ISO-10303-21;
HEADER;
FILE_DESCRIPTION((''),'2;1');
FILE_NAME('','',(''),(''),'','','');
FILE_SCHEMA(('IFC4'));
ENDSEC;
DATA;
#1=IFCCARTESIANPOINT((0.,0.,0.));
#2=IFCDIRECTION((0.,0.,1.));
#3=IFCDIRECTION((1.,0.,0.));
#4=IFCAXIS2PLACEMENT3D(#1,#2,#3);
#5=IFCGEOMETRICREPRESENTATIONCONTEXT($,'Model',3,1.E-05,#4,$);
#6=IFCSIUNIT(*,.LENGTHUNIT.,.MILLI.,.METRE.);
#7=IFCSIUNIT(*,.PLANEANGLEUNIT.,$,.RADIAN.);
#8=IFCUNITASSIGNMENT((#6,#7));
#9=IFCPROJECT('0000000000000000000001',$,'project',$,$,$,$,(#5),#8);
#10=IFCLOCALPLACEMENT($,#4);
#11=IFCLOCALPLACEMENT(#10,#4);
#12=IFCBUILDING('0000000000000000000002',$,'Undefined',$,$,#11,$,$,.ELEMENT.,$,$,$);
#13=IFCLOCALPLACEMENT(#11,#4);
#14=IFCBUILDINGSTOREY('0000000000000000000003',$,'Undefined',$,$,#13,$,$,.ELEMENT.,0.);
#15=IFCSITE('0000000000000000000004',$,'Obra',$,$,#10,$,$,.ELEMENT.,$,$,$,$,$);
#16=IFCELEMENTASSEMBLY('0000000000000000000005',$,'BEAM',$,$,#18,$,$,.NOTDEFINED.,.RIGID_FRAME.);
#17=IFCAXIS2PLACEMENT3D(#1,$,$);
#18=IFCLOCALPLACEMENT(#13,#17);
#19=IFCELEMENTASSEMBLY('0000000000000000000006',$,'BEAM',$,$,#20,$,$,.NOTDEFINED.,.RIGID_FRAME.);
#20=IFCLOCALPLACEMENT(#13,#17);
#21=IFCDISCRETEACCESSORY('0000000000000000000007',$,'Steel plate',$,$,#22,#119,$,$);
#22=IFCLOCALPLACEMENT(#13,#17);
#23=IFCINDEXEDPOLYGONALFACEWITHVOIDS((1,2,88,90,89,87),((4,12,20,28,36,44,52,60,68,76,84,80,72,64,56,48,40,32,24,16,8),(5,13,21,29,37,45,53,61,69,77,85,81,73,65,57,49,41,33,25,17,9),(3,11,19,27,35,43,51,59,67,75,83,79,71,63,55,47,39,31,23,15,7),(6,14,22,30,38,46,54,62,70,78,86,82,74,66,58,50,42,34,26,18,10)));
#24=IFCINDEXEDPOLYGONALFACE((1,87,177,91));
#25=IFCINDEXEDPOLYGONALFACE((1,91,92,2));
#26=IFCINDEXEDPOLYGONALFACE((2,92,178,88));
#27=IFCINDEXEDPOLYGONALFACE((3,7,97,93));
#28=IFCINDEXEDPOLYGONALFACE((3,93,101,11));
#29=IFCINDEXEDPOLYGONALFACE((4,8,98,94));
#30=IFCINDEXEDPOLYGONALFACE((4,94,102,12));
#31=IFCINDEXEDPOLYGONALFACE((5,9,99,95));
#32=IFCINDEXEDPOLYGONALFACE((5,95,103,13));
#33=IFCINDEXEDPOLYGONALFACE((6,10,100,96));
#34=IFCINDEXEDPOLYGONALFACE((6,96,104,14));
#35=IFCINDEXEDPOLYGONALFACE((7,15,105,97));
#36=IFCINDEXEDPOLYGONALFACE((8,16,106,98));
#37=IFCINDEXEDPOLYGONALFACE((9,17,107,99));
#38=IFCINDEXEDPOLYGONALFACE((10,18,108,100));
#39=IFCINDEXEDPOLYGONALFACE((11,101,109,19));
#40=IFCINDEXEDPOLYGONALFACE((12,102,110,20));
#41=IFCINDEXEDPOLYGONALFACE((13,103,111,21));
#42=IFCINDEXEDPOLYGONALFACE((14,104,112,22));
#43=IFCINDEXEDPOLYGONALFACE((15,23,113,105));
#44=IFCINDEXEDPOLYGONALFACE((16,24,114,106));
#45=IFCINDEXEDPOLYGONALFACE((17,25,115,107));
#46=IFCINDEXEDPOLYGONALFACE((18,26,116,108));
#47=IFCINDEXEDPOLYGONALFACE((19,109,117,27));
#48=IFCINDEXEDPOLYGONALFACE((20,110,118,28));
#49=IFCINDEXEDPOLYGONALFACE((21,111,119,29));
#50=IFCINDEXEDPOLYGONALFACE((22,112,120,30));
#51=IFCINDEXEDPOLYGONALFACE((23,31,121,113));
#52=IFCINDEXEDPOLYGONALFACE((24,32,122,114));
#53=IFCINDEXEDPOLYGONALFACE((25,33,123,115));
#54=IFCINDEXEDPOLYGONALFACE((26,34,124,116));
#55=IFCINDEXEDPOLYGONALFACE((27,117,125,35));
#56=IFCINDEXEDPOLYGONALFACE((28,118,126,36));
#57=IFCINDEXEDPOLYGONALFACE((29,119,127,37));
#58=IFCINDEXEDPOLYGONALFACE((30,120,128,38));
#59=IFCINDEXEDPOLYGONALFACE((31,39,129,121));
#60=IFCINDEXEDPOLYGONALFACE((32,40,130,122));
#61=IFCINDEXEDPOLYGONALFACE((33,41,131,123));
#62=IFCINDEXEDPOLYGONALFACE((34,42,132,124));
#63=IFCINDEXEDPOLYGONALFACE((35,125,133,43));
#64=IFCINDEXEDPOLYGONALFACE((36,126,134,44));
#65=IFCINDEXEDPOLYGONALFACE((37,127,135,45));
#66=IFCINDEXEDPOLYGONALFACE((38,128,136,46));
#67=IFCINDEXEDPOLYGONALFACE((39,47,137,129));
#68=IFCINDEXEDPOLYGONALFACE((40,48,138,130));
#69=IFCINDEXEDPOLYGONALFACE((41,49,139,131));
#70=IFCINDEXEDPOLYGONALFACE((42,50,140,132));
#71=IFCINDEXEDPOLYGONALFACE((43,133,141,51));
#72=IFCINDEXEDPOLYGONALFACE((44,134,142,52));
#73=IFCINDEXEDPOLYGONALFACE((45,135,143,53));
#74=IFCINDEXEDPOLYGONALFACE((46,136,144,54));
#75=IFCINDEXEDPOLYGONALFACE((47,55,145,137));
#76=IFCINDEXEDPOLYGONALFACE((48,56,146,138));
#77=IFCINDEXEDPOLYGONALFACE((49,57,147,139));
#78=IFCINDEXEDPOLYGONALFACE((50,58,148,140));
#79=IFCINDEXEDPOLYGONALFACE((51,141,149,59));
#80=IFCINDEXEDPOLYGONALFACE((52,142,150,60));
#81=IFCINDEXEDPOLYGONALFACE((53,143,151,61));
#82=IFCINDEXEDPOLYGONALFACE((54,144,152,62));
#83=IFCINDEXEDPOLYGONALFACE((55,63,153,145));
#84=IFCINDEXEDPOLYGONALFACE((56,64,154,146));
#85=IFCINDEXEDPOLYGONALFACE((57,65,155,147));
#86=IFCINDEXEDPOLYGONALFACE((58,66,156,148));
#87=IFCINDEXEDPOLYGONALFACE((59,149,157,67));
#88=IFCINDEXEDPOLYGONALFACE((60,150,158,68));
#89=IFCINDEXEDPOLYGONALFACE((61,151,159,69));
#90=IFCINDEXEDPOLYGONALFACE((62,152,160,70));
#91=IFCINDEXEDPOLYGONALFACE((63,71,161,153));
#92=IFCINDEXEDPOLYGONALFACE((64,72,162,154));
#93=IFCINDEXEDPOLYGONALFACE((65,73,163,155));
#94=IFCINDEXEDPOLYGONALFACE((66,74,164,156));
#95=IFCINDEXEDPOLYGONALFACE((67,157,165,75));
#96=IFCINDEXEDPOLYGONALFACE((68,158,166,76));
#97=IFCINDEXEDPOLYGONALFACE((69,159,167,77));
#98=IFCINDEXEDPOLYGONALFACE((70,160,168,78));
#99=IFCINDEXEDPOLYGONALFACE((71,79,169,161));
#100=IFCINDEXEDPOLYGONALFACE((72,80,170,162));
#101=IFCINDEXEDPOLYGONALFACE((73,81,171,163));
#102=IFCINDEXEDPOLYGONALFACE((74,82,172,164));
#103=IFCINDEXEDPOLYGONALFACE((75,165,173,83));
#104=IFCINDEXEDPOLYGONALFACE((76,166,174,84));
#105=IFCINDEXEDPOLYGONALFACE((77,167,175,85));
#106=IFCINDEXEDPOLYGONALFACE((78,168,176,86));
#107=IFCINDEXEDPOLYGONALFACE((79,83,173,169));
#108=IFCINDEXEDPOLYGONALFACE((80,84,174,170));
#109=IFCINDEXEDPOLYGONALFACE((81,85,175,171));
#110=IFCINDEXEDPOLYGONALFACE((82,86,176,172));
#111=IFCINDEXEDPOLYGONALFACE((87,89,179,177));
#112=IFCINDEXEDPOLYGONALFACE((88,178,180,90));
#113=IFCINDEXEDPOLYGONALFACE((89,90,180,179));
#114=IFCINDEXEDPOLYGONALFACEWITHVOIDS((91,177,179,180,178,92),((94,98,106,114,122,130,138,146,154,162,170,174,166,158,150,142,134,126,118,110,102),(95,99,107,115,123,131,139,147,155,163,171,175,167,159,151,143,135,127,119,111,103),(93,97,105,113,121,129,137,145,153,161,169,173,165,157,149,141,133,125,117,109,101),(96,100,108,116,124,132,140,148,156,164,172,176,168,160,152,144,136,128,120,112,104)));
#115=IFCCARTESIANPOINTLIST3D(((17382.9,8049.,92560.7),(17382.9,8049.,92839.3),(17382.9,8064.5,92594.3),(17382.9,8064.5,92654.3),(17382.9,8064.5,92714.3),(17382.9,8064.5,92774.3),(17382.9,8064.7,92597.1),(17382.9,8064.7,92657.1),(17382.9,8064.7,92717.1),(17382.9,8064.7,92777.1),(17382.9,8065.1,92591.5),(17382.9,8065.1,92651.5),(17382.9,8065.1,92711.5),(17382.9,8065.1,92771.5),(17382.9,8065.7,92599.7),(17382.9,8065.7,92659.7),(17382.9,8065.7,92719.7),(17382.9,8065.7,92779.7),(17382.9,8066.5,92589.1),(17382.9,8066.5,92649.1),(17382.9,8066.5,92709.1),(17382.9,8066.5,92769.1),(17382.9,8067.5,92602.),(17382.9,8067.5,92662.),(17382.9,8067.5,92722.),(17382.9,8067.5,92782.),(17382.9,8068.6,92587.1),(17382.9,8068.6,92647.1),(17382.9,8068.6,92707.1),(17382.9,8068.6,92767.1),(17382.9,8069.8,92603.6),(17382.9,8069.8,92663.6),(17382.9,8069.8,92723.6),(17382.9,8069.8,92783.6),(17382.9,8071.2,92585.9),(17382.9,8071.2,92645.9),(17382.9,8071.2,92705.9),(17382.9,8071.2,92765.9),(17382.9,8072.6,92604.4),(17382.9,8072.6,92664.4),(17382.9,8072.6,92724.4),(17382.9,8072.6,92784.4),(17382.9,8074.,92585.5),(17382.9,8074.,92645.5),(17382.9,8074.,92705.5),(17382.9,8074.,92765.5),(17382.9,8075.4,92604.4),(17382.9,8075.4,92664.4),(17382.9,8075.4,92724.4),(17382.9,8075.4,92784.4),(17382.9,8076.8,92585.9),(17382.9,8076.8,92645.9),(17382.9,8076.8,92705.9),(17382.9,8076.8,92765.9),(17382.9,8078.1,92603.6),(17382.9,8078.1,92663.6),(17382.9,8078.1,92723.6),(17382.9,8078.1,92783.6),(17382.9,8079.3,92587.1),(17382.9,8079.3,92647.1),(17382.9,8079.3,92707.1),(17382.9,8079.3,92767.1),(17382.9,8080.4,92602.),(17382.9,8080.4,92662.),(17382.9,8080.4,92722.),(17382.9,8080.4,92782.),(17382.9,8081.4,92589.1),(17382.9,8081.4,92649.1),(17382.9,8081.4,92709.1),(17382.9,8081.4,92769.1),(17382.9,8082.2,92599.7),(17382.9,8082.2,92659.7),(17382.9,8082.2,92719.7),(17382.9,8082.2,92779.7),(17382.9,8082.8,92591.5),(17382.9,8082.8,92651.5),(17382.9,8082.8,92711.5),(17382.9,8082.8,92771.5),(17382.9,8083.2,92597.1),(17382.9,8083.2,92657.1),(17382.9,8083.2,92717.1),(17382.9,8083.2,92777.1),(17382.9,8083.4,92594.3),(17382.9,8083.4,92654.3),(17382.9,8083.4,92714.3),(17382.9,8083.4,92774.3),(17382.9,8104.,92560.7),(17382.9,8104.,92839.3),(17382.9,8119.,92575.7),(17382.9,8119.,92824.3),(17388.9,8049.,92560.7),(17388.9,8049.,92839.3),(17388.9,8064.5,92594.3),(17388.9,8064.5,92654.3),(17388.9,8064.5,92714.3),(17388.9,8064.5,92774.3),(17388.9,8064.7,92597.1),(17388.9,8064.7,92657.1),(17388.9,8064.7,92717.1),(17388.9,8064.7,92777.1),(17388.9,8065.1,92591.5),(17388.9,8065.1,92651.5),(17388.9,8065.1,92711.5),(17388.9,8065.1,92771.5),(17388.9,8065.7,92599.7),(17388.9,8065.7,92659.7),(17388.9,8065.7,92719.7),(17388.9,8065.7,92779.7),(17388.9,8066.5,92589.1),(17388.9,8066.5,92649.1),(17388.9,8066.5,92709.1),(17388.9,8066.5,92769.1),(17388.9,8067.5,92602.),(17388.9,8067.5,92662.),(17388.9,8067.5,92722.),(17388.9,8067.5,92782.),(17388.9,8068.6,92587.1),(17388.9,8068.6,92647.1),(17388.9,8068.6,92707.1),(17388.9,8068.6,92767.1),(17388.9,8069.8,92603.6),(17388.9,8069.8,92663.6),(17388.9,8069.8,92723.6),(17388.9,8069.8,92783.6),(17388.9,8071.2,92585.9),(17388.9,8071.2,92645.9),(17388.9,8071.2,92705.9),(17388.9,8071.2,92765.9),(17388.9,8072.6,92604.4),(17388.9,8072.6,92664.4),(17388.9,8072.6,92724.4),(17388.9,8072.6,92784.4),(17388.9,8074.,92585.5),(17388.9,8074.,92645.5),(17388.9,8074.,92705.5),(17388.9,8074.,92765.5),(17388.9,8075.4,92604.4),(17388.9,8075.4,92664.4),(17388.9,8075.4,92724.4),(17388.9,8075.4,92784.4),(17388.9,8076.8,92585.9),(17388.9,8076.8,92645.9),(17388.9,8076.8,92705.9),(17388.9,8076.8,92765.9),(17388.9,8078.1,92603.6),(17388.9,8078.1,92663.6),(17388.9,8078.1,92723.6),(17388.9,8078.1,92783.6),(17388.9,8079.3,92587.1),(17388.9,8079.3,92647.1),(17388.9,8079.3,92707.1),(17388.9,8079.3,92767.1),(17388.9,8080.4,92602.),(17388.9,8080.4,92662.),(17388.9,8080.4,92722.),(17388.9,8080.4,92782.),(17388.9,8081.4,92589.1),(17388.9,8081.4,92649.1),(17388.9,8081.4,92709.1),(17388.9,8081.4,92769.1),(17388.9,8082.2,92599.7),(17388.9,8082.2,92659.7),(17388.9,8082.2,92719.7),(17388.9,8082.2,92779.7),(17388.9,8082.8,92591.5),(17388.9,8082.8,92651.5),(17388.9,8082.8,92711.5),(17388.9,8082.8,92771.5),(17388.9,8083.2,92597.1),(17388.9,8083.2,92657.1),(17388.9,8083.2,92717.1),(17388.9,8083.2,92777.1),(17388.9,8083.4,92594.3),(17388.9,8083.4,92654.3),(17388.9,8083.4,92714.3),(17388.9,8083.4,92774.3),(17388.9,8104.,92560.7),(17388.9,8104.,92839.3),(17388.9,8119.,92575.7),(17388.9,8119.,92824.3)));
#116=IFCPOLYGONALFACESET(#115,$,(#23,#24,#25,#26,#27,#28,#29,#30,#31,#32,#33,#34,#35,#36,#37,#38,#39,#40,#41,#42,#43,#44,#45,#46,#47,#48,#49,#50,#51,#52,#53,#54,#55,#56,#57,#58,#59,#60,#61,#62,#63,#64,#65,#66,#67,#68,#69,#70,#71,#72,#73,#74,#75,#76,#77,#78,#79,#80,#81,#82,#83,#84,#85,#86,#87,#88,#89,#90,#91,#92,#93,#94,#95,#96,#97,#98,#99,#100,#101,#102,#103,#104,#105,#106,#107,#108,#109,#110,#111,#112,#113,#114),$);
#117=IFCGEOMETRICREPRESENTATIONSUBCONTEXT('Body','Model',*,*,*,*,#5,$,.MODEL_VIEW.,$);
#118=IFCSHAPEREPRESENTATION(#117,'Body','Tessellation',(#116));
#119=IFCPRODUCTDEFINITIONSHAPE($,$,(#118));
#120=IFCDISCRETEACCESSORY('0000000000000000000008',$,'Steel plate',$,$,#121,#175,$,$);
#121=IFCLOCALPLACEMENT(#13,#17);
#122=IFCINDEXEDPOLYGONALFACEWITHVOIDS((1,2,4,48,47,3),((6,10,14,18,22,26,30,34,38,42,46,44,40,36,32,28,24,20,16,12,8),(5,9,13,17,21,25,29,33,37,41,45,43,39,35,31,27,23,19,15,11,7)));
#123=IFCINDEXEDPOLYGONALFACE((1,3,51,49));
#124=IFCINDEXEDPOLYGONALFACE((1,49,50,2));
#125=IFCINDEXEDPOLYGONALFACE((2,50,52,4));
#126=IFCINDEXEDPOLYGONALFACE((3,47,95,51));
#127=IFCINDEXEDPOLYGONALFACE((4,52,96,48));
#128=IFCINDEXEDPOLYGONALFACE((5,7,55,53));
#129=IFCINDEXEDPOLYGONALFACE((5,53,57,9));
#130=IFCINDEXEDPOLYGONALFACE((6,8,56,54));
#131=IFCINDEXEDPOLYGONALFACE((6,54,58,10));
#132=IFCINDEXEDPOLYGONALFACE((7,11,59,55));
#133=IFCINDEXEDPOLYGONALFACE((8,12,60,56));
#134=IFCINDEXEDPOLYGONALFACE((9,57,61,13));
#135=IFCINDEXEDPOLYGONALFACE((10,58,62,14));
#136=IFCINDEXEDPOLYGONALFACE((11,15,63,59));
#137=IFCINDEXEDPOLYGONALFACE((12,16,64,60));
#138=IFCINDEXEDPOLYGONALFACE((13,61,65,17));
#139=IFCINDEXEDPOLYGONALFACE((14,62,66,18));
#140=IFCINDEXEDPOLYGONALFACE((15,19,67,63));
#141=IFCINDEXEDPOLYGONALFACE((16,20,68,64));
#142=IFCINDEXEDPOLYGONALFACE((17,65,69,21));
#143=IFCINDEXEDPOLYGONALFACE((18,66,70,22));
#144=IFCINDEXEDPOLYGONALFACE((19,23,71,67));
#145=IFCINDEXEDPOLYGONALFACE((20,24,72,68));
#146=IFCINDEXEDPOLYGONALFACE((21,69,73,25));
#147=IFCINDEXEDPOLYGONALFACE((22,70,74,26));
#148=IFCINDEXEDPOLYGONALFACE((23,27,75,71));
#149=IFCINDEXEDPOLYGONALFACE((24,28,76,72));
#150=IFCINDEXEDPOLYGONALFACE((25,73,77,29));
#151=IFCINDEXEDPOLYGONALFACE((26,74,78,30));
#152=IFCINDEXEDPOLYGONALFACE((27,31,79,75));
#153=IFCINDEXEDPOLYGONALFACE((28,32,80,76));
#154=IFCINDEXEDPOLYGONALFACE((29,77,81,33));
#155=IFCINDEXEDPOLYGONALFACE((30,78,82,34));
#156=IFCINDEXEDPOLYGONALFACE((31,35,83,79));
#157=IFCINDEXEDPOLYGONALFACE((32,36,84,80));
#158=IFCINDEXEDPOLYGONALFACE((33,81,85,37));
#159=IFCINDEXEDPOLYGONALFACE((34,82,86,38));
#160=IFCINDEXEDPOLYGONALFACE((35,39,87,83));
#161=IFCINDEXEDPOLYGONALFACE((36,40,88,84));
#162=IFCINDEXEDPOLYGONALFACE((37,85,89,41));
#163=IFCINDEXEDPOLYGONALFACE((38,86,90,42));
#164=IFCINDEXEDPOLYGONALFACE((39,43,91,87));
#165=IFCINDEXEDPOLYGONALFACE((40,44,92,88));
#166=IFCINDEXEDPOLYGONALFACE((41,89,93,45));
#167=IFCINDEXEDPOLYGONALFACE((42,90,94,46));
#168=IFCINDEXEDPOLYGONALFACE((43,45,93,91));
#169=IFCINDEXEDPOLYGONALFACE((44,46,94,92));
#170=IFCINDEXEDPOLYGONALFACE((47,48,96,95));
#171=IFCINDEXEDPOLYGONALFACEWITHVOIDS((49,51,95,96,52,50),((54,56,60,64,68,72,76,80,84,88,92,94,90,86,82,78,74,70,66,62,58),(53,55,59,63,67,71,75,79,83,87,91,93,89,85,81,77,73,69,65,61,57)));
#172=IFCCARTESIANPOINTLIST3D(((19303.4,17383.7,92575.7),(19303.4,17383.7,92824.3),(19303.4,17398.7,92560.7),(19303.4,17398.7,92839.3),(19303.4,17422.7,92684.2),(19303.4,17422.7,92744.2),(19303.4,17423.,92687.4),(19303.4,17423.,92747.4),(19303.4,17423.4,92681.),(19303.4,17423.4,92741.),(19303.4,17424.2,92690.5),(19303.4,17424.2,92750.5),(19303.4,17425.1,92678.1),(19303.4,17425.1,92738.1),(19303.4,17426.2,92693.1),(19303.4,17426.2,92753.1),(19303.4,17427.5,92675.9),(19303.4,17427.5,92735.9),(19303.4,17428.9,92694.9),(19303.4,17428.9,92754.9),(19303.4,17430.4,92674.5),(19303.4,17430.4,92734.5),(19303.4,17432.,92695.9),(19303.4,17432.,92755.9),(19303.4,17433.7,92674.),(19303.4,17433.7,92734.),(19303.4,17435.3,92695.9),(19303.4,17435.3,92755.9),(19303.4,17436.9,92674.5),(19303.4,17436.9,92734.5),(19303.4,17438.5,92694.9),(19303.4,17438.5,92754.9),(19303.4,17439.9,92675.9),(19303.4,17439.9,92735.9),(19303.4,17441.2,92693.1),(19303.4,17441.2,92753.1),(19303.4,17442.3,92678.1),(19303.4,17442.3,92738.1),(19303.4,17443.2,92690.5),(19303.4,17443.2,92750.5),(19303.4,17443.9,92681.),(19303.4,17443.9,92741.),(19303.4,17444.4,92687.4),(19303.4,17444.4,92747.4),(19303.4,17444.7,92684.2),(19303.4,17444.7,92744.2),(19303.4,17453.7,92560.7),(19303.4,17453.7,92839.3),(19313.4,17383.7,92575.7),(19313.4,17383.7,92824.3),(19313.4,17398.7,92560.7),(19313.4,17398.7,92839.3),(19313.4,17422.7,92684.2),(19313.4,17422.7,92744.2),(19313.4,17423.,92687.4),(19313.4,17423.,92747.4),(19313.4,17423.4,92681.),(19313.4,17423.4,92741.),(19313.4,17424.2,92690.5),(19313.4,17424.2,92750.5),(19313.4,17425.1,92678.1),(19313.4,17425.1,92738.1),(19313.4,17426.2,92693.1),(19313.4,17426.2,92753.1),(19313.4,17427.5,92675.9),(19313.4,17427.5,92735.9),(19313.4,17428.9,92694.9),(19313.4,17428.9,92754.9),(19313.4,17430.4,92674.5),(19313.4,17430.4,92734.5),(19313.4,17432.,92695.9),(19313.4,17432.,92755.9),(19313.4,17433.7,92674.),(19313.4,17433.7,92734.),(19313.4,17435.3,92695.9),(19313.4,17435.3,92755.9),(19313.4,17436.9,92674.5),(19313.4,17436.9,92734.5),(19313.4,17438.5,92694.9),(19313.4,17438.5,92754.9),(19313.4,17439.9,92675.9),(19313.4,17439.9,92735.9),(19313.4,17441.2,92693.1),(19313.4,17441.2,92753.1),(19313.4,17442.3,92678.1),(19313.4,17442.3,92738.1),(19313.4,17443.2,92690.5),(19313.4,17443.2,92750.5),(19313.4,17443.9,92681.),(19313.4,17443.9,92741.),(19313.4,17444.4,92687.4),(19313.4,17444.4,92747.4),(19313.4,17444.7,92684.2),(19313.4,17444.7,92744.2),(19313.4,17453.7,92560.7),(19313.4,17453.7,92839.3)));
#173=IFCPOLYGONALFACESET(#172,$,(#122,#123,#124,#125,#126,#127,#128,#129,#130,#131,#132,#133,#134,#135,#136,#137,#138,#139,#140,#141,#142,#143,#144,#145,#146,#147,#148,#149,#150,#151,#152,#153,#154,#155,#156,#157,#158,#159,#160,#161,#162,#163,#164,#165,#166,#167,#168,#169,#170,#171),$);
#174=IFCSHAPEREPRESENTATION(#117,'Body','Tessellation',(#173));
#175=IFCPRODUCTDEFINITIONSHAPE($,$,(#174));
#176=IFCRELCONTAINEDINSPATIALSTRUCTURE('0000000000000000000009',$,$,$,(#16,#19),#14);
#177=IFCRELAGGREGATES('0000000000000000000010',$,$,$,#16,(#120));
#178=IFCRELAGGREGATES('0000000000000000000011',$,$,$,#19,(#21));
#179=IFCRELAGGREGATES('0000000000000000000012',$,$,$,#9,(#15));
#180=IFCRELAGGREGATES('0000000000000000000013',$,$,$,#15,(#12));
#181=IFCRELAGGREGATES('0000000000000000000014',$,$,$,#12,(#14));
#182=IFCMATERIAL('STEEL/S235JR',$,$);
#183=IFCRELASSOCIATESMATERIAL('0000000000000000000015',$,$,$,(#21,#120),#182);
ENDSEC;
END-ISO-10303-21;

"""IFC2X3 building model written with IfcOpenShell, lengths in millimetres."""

from ifc_helpers import new_model, si_unit, frame, origin_with_axes, origin_2d_with_axis, place, context, subcontext, project, spatial, polyline, circle, outline, extrude, source, transform, mapped, material, element, aggregate, save


model = new_model("IFC2X3")

# Units and contexts
model_context = context("Model", 3, precision=1e-05, world=origin_with_axes())
body_context = subcontext(model_context, "Body", "Model", "MODEL_VIEW")
ifc_project = project(units=[si_unit("LENGTHUNIT", "METRE", prefix="MILLI"), si_unit("PLANEANGLEUNIT", "RADIAN")], contexts=[model_context])

# Site, building, storey
site_placement = place(None, origin_with_axes())
site = spatial("IfcSite", under=ifc_project, at=site_placement, Name="Obra", CompositionType="ELEMENT")
building_placement = place(site_placement, origin_with_axes())
building = spatial("IfcBuilding", under=site, at=building_placement, Name="Undefined", CompositionType="ELEMENT")
storey_placement = place(building_placement, origin_with_axes())
storey = spatial("IfcBuildingStorey", under=building, at=storey_placement, Name="Undefined", CompositionType="ELEMENT", Elevation=0.0)

# Element assemblies, discrete accessory, opening
assembly_1_placement = place(storey_placement, origin_with_axes())
assembly_1 = element("IfcElementAssembly", 1, at=assembly_1_placement, inside=storey, Name="BEAM", AssemblyPlace="NOTDEFINED", PredefinedType="RIGID_FRAME")
ifc_material_1 = material(Name="STEEL/S235JR")
shared_shape_1 = source(origin_with_axes(), body_context, "Body", "SweptSolid", [
    extrude(circle(Radius=9.5, at=origin_2d_with_axis()), frame((0.0, -9.8, 0.0), z_axis=(0.0, 1.0, 0.0), x_axis=(1.0, 0.0, 0.0)), (0.0, 0.0, 1.0), 6.2),
])
assembly_2_placement = place(storey_placement, origin_with_axes())
assembly_2 = element("IfcElementAssembly", 2, at=assembly_2_placement, inside=storey, Name="BEAM", AssemblyPlace="NOTDEFINED", PredefinedType="RIGID_FRAME")
discrete_accessory_1_placement = place(assembly_2_placement, frame((17385.9, 8049.0, 92560.7), z_axis=(1.0, 0.0, 0.0), x_axis=(0.0, 1.0, 0.0)))
discrete_accessory_1 = element("IfcDiscreteAccessory", 3, at=discrete_accessory_1_placement, material=ifc_material_1, Name="Steel plate", context=body_context, shape_type="SweptSolid", body=[
    extrude(outline(polyline([(0.0, 0.0), (55.0, 0.0), (70.0, 15.0), (70.0, 263.6), (55.0, 278.6), (0.0, 278.6), (0.0, 0.0)])), frame((0.0, 0.0, -3.0), z_axis=(0.0, 0.0, 1.0), x_axis=(1.0, 0.0, 0.0)), (0.0, 0.0, 1.0), 6.0),
])
opening_1_placement = place(assembly_2_placement, frame((17392.7, 8109.0, 92850.0), z_axis=(0.0, -1.0, 0.0), x_axis=(0.0, 0.0, -1.0)))
element("IfcOpeningElement", 4, at=opening_1_placement, cuts=discrete_accessory_1, ObjectType="Opening", context=body_context, shape_type="MappedRepresentation", body=[
    mapped(shared_shape_1, transform((75.0, 0.0, 35.0))),
    mapped(shared_shape_1, transform((135.0, 0.0, 35.0))),
    mapped(shared_shape_1, transform((195.0, 0.0, 35.0))),
    mapped(shared_shape_1, transform((255.0, 0.0, 35.0))),
])

# Discrete accessory, opening
discrete_accessory_2_placement = place(assembly_1_placement, frame((19308.4, 17453.7, 92560.7), z_axis=(-1.0, 0.0, 0.0), x_axis=(0.0, -1.0, 0.0)))
discrete_accessory_2 = element("IfcDiscreteAccessory", 5, at=discrete_accessory_2_placement, material=ifc_material_1, Name="Steel plate", context=body_context, shape_type="SweptSolid", body=[
    extrude(outline(polyline([(0.0, 0.0), (55.0, 0.0), (70.0, 15.0), (70.0, 263.6), (55.0, 278.6), (0.0, 278.6), (0.0, 0.0)])), frame((0.0, 0.0, -5.0), z_axis=(0.0, 0.0, 1.0), x_axis=(1.0, 0.0, 0.0)), (0.0, 0.0, 1.0), 10.0),
])
shared_shape_2 = source(origin_with_axes(), body_context, "Body", "SweptSolid", [
    extrude(circle(Radius=11.0, at=origin_2d_with_axis()), frame((0.0, -13.4, 0.0), z_axis=(0.0, 1.0, 0.0), x_axis=(1.0, 0.0, 0.0)), (0.0, 0.0, 1.0), 10.2),
])
opening_2_placement = place(assembly_1_placement, frame((19300.1, 17393.7, 92850.0), z_axis=(0.0, 1.0, 0.0), x_axis=(0.0, 0.0, -1.0)))
element("IfcOpeningElement", 6, at=opening_2_placement, cuts=discrete_accessory_2, ObjectType="Opening", context=body_context, shape_type="MappedRepresentation", body=[
    mapped(shared_shape_2, transform((105.0, 0.0, 40.0))),
    mapped(shared_shape_2, transform((165.0, 0.0, 40.0))),
])
aggregate(assembly_1, [discrete_accessory_2])
aggregate(assembly_2, [discrete_accessory_1])

save(model, "model.ifc")
